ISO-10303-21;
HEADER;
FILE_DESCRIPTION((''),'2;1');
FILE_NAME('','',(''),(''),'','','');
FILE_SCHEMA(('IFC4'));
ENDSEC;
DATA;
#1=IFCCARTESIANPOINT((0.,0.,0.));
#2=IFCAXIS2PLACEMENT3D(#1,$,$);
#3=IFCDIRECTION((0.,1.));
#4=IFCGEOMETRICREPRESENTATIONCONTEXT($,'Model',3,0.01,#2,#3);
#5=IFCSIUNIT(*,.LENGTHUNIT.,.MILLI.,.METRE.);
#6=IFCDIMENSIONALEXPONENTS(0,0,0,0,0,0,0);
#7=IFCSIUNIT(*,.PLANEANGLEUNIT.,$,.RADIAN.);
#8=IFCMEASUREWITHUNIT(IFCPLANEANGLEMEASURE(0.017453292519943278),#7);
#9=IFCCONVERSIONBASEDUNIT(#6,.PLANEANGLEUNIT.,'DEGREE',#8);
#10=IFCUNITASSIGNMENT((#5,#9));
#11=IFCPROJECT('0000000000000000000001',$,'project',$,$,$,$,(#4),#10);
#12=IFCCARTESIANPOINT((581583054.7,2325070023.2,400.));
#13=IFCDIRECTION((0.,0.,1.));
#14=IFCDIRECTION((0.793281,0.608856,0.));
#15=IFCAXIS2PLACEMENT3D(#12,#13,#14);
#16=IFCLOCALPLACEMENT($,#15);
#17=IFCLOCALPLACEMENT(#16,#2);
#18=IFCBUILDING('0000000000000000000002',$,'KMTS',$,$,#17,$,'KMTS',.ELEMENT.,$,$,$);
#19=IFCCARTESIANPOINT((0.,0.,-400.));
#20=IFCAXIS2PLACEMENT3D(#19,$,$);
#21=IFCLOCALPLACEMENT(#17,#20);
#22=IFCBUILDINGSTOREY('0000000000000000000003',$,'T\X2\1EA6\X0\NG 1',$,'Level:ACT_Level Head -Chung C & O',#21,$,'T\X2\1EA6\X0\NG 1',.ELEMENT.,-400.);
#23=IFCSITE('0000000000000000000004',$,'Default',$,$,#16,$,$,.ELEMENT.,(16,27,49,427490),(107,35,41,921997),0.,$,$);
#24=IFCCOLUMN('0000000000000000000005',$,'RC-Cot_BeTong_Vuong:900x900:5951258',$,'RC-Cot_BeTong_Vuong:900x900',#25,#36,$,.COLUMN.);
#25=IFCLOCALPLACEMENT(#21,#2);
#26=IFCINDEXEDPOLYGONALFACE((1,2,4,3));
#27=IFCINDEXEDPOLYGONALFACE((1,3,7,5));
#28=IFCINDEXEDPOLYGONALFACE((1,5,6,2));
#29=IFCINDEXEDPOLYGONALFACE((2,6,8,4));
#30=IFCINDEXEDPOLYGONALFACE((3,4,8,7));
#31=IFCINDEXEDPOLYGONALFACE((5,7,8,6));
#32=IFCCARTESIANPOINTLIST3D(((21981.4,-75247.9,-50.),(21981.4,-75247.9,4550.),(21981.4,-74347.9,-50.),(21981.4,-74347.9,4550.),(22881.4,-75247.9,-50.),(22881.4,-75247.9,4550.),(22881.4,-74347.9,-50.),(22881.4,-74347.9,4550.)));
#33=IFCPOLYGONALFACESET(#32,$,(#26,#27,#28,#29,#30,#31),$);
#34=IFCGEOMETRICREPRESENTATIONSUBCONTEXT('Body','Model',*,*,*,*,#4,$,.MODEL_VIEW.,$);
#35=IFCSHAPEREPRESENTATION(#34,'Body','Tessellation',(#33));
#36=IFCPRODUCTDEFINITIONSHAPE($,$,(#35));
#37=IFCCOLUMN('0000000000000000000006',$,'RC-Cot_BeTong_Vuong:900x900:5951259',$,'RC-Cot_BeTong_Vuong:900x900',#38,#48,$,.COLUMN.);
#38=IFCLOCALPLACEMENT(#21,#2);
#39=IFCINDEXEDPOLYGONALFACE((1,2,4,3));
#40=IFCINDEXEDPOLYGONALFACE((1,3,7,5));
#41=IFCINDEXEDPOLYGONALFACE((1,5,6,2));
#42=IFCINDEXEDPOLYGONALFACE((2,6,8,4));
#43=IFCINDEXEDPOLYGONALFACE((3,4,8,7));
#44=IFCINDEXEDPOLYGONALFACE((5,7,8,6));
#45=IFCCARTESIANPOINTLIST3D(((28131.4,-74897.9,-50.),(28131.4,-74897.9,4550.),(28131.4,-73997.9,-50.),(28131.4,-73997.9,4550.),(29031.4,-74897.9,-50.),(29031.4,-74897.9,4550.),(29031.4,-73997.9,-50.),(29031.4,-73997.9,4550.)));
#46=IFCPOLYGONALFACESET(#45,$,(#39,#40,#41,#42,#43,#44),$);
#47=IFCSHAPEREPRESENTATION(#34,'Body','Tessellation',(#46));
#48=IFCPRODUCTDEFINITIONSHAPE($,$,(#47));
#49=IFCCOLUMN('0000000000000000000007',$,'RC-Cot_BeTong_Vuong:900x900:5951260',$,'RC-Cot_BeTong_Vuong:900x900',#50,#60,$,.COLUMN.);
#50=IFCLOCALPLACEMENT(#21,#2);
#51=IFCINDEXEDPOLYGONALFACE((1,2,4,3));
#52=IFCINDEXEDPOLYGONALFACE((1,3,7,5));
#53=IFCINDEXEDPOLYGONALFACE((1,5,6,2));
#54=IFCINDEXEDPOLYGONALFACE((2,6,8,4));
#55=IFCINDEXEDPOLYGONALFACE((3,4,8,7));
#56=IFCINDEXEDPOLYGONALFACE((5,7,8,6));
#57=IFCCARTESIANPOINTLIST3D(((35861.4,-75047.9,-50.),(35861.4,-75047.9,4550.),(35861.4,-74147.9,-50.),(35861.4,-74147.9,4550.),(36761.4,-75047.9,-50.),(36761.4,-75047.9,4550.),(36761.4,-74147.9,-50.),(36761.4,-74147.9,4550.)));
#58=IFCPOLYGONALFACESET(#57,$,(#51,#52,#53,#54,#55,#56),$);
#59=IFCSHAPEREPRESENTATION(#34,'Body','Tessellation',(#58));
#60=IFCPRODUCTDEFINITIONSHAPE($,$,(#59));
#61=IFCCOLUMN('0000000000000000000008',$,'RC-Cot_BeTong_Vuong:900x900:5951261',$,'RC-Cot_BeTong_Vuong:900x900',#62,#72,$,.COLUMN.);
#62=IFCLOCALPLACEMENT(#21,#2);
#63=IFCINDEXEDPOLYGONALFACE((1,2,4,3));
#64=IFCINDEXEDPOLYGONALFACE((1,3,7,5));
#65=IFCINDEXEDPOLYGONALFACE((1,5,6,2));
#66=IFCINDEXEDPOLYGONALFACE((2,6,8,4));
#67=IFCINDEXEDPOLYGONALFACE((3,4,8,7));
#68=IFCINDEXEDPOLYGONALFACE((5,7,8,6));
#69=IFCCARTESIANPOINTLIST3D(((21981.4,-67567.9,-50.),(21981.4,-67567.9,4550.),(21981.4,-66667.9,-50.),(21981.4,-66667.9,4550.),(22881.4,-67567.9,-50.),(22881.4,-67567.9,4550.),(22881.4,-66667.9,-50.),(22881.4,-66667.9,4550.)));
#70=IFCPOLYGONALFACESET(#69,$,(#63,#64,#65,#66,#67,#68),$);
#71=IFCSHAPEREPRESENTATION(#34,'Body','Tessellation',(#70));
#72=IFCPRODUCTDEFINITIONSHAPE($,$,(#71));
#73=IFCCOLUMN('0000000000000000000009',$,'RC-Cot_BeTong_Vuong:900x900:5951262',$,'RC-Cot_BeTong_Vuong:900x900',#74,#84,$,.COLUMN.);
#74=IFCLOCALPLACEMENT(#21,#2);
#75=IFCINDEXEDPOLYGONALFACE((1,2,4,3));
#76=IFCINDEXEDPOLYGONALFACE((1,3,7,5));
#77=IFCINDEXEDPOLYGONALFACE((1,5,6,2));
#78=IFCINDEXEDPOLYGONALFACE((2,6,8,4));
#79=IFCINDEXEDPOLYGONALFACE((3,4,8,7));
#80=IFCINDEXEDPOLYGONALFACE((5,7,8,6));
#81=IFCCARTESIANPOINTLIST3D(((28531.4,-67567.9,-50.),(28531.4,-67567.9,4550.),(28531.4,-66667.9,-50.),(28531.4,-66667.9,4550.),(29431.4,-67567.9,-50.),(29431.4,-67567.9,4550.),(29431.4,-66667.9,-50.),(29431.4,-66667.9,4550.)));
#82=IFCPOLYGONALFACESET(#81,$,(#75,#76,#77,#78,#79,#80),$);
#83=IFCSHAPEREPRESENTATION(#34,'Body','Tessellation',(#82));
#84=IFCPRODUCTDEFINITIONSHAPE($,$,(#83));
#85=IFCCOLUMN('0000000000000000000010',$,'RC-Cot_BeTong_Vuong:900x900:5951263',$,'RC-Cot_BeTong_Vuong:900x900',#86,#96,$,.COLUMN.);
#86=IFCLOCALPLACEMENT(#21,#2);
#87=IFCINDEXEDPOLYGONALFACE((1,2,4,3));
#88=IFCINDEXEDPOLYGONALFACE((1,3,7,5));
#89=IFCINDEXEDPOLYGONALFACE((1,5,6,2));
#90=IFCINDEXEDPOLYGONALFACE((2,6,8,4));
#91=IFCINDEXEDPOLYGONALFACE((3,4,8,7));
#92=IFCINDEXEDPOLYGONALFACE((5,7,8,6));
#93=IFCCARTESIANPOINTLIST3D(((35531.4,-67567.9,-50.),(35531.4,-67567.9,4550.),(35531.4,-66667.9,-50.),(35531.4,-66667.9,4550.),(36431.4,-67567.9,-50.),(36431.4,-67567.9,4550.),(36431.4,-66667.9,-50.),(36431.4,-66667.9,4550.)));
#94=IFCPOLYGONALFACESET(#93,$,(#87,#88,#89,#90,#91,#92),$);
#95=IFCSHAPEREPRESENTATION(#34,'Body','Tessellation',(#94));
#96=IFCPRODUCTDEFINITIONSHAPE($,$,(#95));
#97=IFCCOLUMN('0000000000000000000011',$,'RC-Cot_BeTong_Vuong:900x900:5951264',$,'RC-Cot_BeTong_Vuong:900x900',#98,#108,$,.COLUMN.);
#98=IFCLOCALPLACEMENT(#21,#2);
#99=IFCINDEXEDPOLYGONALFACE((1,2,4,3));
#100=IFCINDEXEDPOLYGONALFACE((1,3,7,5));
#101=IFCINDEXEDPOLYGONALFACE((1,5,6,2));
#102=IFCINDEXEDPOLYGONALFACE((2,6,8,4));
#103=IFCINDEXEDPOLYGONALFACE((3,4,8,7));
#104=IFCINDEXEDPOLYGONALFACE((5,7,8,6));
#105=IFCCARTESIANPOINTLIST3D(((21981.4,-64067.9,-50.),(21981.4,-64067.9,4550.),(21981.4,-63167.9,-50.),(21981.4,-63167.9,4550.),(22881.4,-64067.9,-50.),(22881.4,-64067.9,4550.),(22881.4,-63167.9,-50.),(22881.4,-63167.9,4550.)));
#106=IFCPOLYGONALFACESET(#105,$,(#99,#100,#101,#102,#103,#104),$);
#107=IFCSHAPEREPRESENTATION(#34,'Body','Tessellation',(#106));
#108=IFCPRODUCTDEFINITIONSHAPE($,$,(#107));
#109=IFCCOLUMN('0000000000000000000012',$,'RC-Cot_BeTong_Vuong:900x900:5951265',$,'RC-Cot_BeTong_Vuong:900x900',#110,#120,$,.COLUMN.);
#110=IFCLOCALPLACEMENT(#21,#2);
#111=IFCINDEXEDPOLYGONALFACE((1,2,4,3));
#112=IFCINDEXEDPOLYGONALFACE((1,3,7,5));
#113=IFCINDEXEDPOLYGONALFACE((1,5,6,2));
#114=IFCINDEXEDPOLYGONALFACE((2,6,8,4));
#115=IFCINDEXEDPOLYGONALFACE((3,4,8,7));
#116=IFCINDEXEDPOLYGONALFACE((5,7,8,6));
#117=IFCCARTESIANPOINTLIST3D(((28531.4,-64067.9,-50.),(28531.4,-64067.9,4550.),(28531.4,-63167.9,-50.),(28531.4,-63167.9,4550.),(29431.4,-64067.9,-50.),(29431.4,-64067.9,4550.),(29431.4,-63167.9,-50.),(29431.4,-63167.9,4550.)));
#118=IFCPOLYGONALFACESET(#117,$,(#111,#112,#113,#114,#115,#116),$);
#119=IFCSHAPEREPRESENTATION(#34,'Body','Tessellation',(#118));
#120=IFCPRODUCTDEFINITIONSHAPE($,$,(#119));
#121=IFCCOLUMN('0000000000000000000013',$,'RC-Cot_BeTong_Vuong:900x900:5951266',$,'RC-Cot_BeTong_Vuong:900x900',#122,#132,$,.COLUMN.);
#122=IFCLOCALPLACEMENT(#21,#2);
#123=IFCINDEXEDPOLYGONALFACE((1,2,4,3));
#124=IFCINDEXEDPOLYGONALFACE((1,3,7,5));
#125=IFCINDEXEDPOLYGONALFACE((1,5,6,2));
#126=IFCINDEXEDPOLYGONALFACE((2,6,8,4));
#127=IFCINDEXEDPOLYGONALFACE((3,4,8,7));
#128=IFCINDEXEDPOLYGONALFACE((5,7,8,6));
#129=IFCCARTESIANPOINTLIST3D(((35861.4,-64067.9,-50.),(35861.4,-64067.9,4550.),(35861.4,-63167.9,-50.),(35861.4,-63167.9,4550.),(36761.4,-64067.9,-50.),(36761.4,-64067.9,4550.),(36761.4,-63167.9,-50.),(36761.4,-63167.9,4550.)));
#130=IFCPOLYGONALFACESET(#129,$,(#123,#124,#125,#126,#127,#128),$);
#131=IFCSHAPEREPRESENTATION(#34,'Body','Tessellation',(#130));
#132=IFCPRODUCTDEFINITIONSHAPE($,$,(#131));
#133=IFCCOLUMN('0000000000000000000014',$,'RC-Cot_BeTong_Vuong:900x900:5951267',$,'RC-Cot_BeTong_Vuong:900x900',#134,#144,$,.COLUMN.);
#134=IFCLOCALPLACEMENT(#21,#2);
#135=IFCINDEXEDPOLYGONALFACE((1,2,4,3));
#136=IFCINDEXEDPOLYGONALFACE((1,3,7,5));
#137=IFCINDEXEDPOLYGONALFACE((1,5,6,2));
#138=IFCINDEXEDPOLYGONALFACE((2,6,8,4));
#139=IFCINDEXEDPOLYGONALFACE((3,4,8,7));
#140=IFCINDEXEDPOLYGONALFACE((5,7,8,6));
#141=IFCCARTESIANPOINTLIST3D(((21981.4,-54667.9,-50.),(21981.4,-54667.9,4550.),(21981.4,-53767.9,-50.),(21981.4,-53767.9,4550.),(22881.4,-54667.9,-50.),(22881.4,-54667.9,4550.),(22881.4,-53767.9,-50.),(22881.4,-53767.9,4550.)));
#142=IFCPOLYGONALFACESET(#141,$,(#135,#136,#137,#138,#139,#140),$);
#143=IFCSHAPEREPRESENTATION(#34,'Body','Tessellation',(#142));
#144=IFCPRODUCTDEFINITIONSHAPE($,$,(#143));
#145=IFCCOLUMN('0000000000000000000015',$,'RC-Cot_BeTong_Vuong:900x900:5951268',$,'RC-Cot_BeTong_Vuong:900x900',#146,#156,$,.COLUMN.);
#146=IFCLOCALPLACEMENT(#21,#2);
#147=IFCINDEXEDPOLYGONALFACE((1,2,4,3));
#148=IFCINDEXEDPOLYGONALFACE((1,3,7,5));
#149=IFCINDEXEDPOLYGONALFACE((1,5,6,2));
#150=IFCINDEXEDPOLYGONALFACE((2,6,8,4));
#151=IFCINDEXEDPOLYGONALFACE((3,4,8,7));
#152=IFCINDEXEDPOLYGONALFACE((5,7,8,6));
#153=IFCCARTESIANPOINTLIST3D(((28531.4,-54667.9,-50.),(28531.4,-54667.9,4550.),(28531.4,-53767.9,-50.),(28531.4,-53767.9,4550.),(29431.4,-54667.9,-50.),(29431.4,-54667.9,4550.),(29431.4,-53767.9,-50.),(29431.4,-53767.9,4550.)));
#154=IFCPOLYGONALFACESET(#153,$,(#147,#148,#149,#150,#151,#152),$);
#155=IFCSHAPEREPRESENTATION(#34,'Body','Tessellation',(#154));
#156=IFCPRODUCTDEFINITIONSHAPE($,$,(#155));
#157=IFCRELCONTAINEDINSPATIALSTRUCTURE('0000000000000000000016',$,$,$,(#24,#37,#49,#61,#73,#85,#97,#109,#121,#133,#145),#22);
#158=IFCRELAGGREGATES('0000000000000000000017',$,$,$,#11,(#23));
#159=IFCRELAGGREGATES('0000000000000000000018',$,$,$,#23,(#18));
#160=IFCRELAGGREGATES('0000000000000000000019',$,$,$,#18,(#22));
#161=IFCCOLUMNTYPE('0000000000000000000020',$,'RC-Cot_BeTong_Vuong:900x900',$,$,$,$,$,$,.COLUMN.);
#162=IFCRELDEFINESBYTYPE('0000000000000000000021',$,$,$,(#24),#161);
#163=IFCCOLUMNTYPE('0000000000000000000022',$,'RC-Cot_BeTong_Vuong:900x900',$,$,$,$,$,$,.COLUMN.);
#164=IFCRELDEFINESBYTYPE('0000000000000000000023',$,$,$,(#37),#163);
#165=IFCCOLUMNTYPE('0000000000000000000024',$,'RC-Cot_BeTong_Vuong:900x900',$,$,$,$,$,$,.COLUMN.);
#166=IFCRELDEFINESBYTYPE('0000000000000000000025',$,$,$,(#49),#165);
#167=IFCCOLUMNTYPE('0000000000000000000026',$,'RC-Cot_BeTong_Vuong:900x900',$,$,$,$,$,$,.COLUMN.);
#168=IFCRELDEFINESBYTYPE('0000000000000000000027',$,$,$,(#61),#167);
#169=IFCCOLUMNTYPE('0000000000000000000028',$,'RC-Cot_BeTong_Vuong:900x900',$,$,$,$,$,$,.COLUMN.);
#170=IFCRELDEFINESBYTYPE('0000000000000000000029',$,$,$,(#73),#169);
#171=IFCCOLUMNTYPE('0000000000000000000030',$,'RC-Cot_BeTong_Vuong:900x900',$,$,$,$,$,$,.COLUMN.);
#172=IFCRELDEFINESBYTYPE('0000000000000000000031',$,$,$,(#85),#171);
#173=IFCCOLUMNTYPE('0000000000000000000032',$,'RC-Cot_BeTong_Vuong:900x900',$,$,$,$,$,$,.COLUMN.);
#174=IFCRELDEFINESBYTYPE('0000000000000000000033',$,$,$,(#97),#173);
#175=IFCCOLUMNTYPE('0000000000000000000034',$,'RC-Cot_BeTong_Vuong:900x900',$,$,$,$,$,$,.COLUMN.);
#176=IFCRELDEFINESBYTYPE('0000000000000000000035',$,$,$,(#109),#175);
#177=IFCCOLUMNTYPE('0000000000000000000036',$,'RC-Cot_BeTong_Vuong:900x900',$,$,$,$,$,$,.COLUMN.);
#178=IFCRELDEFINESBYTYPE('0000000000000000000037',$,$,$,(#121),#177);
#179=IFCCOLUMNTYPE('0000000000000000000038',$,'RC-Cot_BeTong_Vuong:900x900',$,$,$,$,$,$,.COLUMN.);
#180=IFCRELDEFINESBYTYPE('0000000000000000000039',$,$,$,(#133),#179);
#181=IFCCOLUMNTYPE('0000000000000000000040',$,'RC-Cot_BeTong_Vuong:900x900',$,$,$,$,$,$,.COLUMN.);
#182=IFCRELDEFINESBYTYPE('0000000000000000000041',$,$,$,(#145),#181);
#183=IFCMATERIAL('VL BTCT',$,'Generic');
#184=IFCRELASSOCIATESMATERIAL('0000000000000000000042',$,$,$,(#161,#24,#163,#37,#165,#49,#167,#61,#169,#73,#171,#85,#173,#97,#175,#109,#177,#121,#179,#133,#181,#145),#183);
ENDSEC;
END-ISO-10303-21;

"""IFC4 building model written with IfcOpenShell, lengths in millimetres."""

from ifc_helpers import new_model, entity, si_unit, converted_unit, direction, frame, origin, place, context, subcontext, project, spatial, indexed_curve, outline, extrude, source, transform, mapped, material, type_object, type_shapes, element, save


model = new_model("IFC4")

# Units and contexts
model_context = context("Model", 3, precision=0.01, world=origin(), true_north=direction((0.0, 1.0)))
body_context = subcontext(model_context, "Body", "Model", "MODEL_VIEW")
ifc_project = project(units=[si_unit("LENGTHUNIT", "METRE", prefix="MILLI"), converted_unit("PLANEANGLEUNIT", "DEGREE", entity("IfcPlaneAngleMeasure", 0.017453292519943278), si_unit("PLANEANGLEUNIT", "RADIAN"), dimensions=[0, 0, 0, 0, 0, 0, 0])], contexts=[model_context])

# Site, building, storey
site_placement = place(None, frame((581583054.7, 2325070023.2, 400.0), z_axis=(0.0, 0.0, 1.0), x_axis=(0.793281, 0.608856, 0.0)))
site = spatial("IfcSite", under=ifc_project, at=site_placement, Name="Default", CompositionType="ELEMENT", RefLatitude=(16, 27, 49, 427490), RefLongitude=(107, 35, 41, 921997), RefElevation=0.0)
building_placement = place(site_placement, origin())
building = spatial("IfcBuilding", under=site, at=building_placement, Name="KMTS", LongName="KMTS", CompositionType="ELEMENT")
storey_placement = place(building_placement, frame((0.0, 0.0, -400.0)))
storey = spatial("IfcBuildingStorey", under=building, at=storey_placement, Name="TẦNG 1", ObjectType="Level:ACT_Level Head -Chung C & O", LongName="TẦNG 1", CompositionType="ELEMENT", Elevation=-400.0)

# Columns
ifc_material = material(Name="VL BTCT", Category="Generic")
column_type_1 = type_object("IfcColumnType", Name="RC-Cot_BeTong_Vuong:900x900", PredefinedType="COLUMN", material=ifc_material)
shared_shape_1 = source(origin(), body_context, "Body", "SweptSolid", [
    extrude(outline(indexed_curve([(-450.0, -450.0), (450.0, -450.0), (450.0, 450.0), (-450.0, 450.0), (-450.0, -450.0)], self_intersect=False)), frame((22431.4, -74797.9, -450.0), z_axis=(0.0, 0.0, 1.0), x_axis=(-1.0, 0.0, 0.0)), (0.0, 0.0, 1.0), 4600.0),
])
type_shapes(column_type_1, [shared_shape_1])
column_1_placement = place(storey_placement, frame((0.0, 0.0, 400.0)))
element("IfcColumn", 1, at=column_1_placement, inside=storey, type_object=column_type_1, material=ifc_material, Name="RC-Cot_BeTong_Vuong:900x900:5951258", ObjectType="RC-Cot_BeTong_Vuong:900x900", PredefinedType="COLUMN", context=body_context, shape_type="MappedRepresentation", body=[
    mapped(shared_shape_1, transform((0.0, 0.0, 0.0), scale=1.0)),
])
column_type_2 = type_object("IfcColumnType", Name="RC-Cot_BeTong_Vuong:900x900", PredefinedType="COLUMN", material=ifc_material)
shared_shape_2 = source(origin(), body_context, "Body", "SweptSolid", [
    extrude(outline(indexed_curve([(-450.0, -450.0), (450.0, -450.0), (450.0, 450.0), (-450.0, 450.0), (-450.0, -450.0)], self_intersect=False)), frame((28581.4, -74447.9, -450.0), z_axis=(0.0, 0.0, 1.0), x_axis=(-1.0, 0.0, 0.0)), (0.0, 0.0, 1.0), 4600.0),
])
type_shapes(column_type_2, [shared_shape_2])
column_2_placement = place(storey_placement, frame((0.0, 0.0, 400.0)))
element("IfcColumn", 2, at=column_2_placement, inside=storey, type_object=column_type_2, material=ifc_material, Name="RC-Cot_BeTong_Vuong:900x900:5951259", ObjectType="RC-Cot_BeTong_Vuong:900x900", PredefinedType="COLUMN", context=body_context, shape_type="MappedRepresentation", body=[
    mapped(shared_shape_2, transform((0.0, 0.0, 0.0), scale=1.0)),
])
column_type_3 = type_object("IfcColumnType", Name="RC-Cot_BeTong_Vuong:900x900", PredefinedType="COLUMN", material=ifc_material)
shared_shape_3 = source(origin(), body_context, "Body", "SweptSolid", [
    extrude(outline(indexed_curve([(-450.0, -450.0), (450.0, -450.0), (450.0, 450.0), (-450.0, 450.0), (-450.0, -450.0)], self_intersect=False)), frame((36311.4, -74597.9, -450.0), z_axis=(0.0, 0.0, 1.0), x_axis=(-1.0, 0.0, 0.0)), (0.0, 0.0, 1.0), 4600.0),
])
type_shapes(column_type_3, [shared_shape_3])
column_3_placement = place(storey_placement, frame((0.0, 0.0, 400.0)))
element("IfcColumn", 3, at=column_3_placement, inside=storey, type_object=column_type_3, material=ifc_material, Name="RC-Cot_BeTong_Vuong:900x900:5951260", ObjectType="RC-Cot_BeTong_Vuong:900x900", PredefinedType="COLUMN", context=body_context, shape_type="MappedRepresentation", body=[
    mapped(shared_shape_3, transform((0.0, 0.0, 0.0), scale=1.0)),
])
column_type_4 = type_object("IfcColumnType", Name="RC-Cot_BeTong_Vuong:900x900", PredefinedType="COLUMN", material=ifc_material)
shared_shape_4 = source(origin(), body_context, "Body", "SweptSolid", [
    extrude(outline(indexed_curve([(-450.0, -450.0), (450.0, -450.0), (450.0, 450.0), (-450.0, 450.0), (-450.0, -450.0)], self_intersect=False)), frame((22431.4, -67117.9, -450.0), z_axis=(0.0, 0.0, 1.0), x_axis=(-1.0, 0.0, 0.0)), (0.0, 0.0, 1.0), 4600.0),
])
type_shapes(column_type_4, [shared_shape_4])
column_4_placement = place(storey_placement, frame((0.0, 0.0, 400.0)))
element("IfcColumn", 4, at=column_4_placement, inside=storey, type_object=column_type_4, material=ifc_material, Name="RC-Cot_BeTong_Vuong:900x900:5951261", ObjectType="RC-Cot_BeTong_Vuong:900x900", PredefinedType="COLUMN", context=body_context, shape_type="MappedRepresentation", body=[
    mapped(shared_shape_4, transform((0.0, 0.0, 0.0), scale=1.0)),
])
column_type_5 = type_object("IfcColumnType", Name="RC-Cot_BeTong_Vuong:900x900", PredefinedType="COLUMN", material=ifc_material)
shared_shape_5 = source(origin(), body_context, "Body", "SweptSolid", [
    extrude(outline(indexed_curve([(-450.0, -450.0), (450.0, -450.0), (450.0, 450.0), (-450.0, 450.0), (-450.0, -450.0)], self_intersect=False)), frame((28981.4, -67117.9, -450.0), z_axis=(0.0, 0.0, 1.0), x_axis=(-1.0, 0.0, 0.0)), (0.0, 0.0, 1.0), 4600.0),
])
type_shapes(column_type_5, [shared_shape_5])
column_5_placement = place(storey_placement, frame((0.0, 0.0, 400.0)))
element("IfcColumn", 5, at=column_5_placement, inside=storey, type_object=column_type_5, material=ifc_material, Name="RC-Cot_BeTong_Vuong:900x900:5951262", ObjectType="RC-Cot_BeTong_Vuong:900x900", PredefinedType="COLUMN", context=body_context, shape_type="MappedRepresentation", body=[
    mapped(shared_shape_5, transform((0.0, 0.0, 0.0), scale=1.0)),
])
column_type_6 = type_object("IfcColumnType", Name="RC-Cot_BeTong_Vuong:900x900", PredefinedType="COLUMN", material=ifc_material)
shared_shape_6 = source(origin(), body_context, "Body", "SweptSolid", [
    extrude(outline(indexed_curve([(-450.0, -450.0), (450.0, -450.0), (450.0, 450.0), (-450.0, 450.0), (-450.0, -450.0)], self_intersect=False)), frame((35981.4, -67117.9, -450.0), z_axis=(0.0, 0.0, 1.0), x_axis=(-1.0, 0.0, 0.0)), (0.0, 0.0, 1.0), 4600.0),
])
type_shapes(column_type_6, [shared_shape_6])
column_6_placement = place(storey_placement, frame((0.0, 0.0, 400.0)))
element("IfcColumn", 6, at=column_6_placement, inside=storey, type_object=column_type_6, material=ifc_material, Name="RC-Cot_BeTong_Vuong:900x900:5951263", ObjectType="RC-Cot_BeTong_Vuong:900x900", PredefinedType="COLUMN", context=body_context, shape_type="MappedRepresentation", body=[
    mapped(shared_shape_6, transform((0.0, 0.0, 0.0), scale=1.0)),
])
column_type_7 = type_object("IfcColumnType", Name="RC-Cot_BeTong_Vuong:900x900", PredefinedType="COLUMN", material=ifc_material)
shared_shape_7 = source(origin(), body_context, "Body", "SweptSolid", [
    extrude(outline(indexed_curve([(-450.0, -450.0), (450.0, -450.0), (450.0, 450.0), (-450.0, 450.0), (-450.0, -450.0)], self_intersect=False)), frame((22431.4, -63617.9, -450.0), z_axis=(0.0, 0.0, 1.0), x_axis=(-1.0, 0.0, 0.0)), (0.0, 0.0, 1.0), 4600.0),
])
type_shapes(column_type_7, [shared_shape_7])
column_7_placement = place(storey_placement, frame((0.0, 0.0, 400.0)))
element("IfcColumn", 7, at=column_7_placement, inside=storey, type_object=column_type_7, material=ifc_material, Name="RC-Cot_BeTong_Vuong:900x900:5951264", ObjectType="RC-Cot_BeTong_Vuong:900x900", PredefinedType="COLUMN", context=body_context, shape_type="MappedRepresentation", body=[
    mapped(shared_shape_7, transform((0.0, 0.0, 0.0), scale=1.0)),
])
column_type_8 = type_object("IfcColumnType", Name="RC-Cot_BeTong_Vuong:900x900", PredefinedType="COLUMN", material=ifc_material)
shared_shape_8 = source(origin(), body_context, "Body", "SweptSolid", [
    extrude(outline(indexed_curve([(-450.0, -450.0), (450.0, -450.0), (450.0, 450.0), (-450.0, 450.0), (-450.0, -450.0)], self_intersect=False)), frame((28981.4, -63617.9, -450.0), z_axis=(0.0, 0.0, 1.0), x_axis=(-1.0, 0.0, 0.0)), (0.0, 0.0, 1.0), 4600.0),
])
type_shapes(column_type_8, [shared_shape_8])
column_8_placement = place(storey_placement, frame((0.0, 0.0, 400.0)))
element("IfcColumn", 8, at=column_8_placement, inside=storey, type_object=column_type_8, material=ifc_material, Name="RC-Cot_BeTong_Vuong:900x900:5951265", ObjectType="RC-Cot_BeTong_Vuong:900x900", PredefinedType="COLUMN", context=body_context, shape_type="MappedRepresentation", body=[
    mapped(shared_shape_8, transform((0.0, 0.0, 0.0), scale=1.0)),
])
column_type_9 = type_object("IfcColumnType", Name="RC-Cot_BeTong_Vuong:900x900", PredefinedType="COLUMN", material=ifc_material)
shared_shape_9 = source(origin(), body_context, "Body", "SweptSolid", [
    extrude(outline(indexed_curve([(-450.0, -450.0), (450.0, -450.0), (450.0, 450.0), (-450.0, 450.0), (-450.0, -450.0)], self_intersect=False)), frame((36311.4, -63617.9, -450.0), z_axis=(0.0, 0.0, 1.0), x_axis=(-1.0, 0.0, 0.0)), (0.0, 0.0, 1.0), 4600.0),
])
type_shapes(column_type_9, [shared_shape_9])
column_9_placement = place(storey_placement, frame((0.0, 0.0, 400.0)))
element("IfcColumn", 9, at=column_9_placement, inside=storey, type_object=column_type_9, material=ifc_material, Name="RC-Cot_BeTong_Vuong:900x900:5951266", ObjectType="RC-Cot_BeTong_Vuong:900x900", PredefinedType="COLUMN", context=body_context, shape_type="MappedRepresentation", body=[
    mapped(shared_shape_9, transform((0.0, 0.0, 0.0), scale=1.0)),
])
column_type_10 = type_object("IfcColumnType", Name="RC-Cot_BeTong_Vuong:900x900", PredefinedType="COLUMN", material=ifc_material)
shared_shape_10 = source(origin(), body_context, "Body", "SweptSolid", [
    extrude(outline(indexed_curve([(-450.0, -450.0), (450.0, -450.0), (450.0, 450.0), (-450.0, 450.0), (-450.0, -450.0)], self_intersect=False)), frame((22431.4, -54217.9, -450.0), z_axis=(0.0, 0.0, 1.0), x_axis=(-1.0, 0.0, 0.0)), (0.0, 0.0, 1.0), 4600.0),
])
type_shapes(column_type_10, [shared_shape_10])
column_10_placement = place(storey_placement, frame((0.0, 0.0, 400.0)))
element("IfcColumn", 10, at=column_10_placement, inside=storey, type_object=column_type_10, material=ifc_material, Name="RC-Cot_BeTong_Vuong:900x900:5951267", ObjectType="RC-Cot_BeTong_Vuong:900x900", PredefinedType="COLUMN", context=body_context, shape_type="MappedRepresentation", body=[
    mapped(shared_shape_10, transform((0.0, 0.0, 0.0), scale=1.0)),
])
column_type_11 = type_object("IfcColumnType", Name="RC-Cot_BeTong_Vuong:900x900", PredefinedType="COLUMN", material=ifc_material)
shared_shape_11 = source(origin(), body_context, "Body", "SweptSolid", [
    extrude(outline(indexed_curve([(-450.0, -450.0), (450.0, -450.0), (450.0, 450.0), (-450.0, 450.0), (-450.0, -450.0)], self_intersect=False)), frame((28981.4, -54217.9, -450.0), z_axis=(0.0, 0.0, 1.0), x_axis=(-1.0, 0.0, 0.0)), (0.0, 0.0, 1.0), 4600.0),
])
type_shapes(column_type_11, [shared_shape_11])
column_11_placement = place(storey_placement, frame((0.0, 0.0, 400.0)))
element("IfcColumn", 11, at=column_11_placement, inside=storey, type_object=column_type_11, material=ifc_material, Name="RC-Cot_BeTong_Vuong:900x900:5951268", ObjectType="RC-Cot_BeTong_Vuong:900x900", PredefinedType="COLUMN", context=body_context, shape_type="MappedRepresentation", body=[
    mapped(shared_shape_11, transform((0.0, 0.0, 0.0), scale=1.0)),
])

save(model, "model.ifc")
